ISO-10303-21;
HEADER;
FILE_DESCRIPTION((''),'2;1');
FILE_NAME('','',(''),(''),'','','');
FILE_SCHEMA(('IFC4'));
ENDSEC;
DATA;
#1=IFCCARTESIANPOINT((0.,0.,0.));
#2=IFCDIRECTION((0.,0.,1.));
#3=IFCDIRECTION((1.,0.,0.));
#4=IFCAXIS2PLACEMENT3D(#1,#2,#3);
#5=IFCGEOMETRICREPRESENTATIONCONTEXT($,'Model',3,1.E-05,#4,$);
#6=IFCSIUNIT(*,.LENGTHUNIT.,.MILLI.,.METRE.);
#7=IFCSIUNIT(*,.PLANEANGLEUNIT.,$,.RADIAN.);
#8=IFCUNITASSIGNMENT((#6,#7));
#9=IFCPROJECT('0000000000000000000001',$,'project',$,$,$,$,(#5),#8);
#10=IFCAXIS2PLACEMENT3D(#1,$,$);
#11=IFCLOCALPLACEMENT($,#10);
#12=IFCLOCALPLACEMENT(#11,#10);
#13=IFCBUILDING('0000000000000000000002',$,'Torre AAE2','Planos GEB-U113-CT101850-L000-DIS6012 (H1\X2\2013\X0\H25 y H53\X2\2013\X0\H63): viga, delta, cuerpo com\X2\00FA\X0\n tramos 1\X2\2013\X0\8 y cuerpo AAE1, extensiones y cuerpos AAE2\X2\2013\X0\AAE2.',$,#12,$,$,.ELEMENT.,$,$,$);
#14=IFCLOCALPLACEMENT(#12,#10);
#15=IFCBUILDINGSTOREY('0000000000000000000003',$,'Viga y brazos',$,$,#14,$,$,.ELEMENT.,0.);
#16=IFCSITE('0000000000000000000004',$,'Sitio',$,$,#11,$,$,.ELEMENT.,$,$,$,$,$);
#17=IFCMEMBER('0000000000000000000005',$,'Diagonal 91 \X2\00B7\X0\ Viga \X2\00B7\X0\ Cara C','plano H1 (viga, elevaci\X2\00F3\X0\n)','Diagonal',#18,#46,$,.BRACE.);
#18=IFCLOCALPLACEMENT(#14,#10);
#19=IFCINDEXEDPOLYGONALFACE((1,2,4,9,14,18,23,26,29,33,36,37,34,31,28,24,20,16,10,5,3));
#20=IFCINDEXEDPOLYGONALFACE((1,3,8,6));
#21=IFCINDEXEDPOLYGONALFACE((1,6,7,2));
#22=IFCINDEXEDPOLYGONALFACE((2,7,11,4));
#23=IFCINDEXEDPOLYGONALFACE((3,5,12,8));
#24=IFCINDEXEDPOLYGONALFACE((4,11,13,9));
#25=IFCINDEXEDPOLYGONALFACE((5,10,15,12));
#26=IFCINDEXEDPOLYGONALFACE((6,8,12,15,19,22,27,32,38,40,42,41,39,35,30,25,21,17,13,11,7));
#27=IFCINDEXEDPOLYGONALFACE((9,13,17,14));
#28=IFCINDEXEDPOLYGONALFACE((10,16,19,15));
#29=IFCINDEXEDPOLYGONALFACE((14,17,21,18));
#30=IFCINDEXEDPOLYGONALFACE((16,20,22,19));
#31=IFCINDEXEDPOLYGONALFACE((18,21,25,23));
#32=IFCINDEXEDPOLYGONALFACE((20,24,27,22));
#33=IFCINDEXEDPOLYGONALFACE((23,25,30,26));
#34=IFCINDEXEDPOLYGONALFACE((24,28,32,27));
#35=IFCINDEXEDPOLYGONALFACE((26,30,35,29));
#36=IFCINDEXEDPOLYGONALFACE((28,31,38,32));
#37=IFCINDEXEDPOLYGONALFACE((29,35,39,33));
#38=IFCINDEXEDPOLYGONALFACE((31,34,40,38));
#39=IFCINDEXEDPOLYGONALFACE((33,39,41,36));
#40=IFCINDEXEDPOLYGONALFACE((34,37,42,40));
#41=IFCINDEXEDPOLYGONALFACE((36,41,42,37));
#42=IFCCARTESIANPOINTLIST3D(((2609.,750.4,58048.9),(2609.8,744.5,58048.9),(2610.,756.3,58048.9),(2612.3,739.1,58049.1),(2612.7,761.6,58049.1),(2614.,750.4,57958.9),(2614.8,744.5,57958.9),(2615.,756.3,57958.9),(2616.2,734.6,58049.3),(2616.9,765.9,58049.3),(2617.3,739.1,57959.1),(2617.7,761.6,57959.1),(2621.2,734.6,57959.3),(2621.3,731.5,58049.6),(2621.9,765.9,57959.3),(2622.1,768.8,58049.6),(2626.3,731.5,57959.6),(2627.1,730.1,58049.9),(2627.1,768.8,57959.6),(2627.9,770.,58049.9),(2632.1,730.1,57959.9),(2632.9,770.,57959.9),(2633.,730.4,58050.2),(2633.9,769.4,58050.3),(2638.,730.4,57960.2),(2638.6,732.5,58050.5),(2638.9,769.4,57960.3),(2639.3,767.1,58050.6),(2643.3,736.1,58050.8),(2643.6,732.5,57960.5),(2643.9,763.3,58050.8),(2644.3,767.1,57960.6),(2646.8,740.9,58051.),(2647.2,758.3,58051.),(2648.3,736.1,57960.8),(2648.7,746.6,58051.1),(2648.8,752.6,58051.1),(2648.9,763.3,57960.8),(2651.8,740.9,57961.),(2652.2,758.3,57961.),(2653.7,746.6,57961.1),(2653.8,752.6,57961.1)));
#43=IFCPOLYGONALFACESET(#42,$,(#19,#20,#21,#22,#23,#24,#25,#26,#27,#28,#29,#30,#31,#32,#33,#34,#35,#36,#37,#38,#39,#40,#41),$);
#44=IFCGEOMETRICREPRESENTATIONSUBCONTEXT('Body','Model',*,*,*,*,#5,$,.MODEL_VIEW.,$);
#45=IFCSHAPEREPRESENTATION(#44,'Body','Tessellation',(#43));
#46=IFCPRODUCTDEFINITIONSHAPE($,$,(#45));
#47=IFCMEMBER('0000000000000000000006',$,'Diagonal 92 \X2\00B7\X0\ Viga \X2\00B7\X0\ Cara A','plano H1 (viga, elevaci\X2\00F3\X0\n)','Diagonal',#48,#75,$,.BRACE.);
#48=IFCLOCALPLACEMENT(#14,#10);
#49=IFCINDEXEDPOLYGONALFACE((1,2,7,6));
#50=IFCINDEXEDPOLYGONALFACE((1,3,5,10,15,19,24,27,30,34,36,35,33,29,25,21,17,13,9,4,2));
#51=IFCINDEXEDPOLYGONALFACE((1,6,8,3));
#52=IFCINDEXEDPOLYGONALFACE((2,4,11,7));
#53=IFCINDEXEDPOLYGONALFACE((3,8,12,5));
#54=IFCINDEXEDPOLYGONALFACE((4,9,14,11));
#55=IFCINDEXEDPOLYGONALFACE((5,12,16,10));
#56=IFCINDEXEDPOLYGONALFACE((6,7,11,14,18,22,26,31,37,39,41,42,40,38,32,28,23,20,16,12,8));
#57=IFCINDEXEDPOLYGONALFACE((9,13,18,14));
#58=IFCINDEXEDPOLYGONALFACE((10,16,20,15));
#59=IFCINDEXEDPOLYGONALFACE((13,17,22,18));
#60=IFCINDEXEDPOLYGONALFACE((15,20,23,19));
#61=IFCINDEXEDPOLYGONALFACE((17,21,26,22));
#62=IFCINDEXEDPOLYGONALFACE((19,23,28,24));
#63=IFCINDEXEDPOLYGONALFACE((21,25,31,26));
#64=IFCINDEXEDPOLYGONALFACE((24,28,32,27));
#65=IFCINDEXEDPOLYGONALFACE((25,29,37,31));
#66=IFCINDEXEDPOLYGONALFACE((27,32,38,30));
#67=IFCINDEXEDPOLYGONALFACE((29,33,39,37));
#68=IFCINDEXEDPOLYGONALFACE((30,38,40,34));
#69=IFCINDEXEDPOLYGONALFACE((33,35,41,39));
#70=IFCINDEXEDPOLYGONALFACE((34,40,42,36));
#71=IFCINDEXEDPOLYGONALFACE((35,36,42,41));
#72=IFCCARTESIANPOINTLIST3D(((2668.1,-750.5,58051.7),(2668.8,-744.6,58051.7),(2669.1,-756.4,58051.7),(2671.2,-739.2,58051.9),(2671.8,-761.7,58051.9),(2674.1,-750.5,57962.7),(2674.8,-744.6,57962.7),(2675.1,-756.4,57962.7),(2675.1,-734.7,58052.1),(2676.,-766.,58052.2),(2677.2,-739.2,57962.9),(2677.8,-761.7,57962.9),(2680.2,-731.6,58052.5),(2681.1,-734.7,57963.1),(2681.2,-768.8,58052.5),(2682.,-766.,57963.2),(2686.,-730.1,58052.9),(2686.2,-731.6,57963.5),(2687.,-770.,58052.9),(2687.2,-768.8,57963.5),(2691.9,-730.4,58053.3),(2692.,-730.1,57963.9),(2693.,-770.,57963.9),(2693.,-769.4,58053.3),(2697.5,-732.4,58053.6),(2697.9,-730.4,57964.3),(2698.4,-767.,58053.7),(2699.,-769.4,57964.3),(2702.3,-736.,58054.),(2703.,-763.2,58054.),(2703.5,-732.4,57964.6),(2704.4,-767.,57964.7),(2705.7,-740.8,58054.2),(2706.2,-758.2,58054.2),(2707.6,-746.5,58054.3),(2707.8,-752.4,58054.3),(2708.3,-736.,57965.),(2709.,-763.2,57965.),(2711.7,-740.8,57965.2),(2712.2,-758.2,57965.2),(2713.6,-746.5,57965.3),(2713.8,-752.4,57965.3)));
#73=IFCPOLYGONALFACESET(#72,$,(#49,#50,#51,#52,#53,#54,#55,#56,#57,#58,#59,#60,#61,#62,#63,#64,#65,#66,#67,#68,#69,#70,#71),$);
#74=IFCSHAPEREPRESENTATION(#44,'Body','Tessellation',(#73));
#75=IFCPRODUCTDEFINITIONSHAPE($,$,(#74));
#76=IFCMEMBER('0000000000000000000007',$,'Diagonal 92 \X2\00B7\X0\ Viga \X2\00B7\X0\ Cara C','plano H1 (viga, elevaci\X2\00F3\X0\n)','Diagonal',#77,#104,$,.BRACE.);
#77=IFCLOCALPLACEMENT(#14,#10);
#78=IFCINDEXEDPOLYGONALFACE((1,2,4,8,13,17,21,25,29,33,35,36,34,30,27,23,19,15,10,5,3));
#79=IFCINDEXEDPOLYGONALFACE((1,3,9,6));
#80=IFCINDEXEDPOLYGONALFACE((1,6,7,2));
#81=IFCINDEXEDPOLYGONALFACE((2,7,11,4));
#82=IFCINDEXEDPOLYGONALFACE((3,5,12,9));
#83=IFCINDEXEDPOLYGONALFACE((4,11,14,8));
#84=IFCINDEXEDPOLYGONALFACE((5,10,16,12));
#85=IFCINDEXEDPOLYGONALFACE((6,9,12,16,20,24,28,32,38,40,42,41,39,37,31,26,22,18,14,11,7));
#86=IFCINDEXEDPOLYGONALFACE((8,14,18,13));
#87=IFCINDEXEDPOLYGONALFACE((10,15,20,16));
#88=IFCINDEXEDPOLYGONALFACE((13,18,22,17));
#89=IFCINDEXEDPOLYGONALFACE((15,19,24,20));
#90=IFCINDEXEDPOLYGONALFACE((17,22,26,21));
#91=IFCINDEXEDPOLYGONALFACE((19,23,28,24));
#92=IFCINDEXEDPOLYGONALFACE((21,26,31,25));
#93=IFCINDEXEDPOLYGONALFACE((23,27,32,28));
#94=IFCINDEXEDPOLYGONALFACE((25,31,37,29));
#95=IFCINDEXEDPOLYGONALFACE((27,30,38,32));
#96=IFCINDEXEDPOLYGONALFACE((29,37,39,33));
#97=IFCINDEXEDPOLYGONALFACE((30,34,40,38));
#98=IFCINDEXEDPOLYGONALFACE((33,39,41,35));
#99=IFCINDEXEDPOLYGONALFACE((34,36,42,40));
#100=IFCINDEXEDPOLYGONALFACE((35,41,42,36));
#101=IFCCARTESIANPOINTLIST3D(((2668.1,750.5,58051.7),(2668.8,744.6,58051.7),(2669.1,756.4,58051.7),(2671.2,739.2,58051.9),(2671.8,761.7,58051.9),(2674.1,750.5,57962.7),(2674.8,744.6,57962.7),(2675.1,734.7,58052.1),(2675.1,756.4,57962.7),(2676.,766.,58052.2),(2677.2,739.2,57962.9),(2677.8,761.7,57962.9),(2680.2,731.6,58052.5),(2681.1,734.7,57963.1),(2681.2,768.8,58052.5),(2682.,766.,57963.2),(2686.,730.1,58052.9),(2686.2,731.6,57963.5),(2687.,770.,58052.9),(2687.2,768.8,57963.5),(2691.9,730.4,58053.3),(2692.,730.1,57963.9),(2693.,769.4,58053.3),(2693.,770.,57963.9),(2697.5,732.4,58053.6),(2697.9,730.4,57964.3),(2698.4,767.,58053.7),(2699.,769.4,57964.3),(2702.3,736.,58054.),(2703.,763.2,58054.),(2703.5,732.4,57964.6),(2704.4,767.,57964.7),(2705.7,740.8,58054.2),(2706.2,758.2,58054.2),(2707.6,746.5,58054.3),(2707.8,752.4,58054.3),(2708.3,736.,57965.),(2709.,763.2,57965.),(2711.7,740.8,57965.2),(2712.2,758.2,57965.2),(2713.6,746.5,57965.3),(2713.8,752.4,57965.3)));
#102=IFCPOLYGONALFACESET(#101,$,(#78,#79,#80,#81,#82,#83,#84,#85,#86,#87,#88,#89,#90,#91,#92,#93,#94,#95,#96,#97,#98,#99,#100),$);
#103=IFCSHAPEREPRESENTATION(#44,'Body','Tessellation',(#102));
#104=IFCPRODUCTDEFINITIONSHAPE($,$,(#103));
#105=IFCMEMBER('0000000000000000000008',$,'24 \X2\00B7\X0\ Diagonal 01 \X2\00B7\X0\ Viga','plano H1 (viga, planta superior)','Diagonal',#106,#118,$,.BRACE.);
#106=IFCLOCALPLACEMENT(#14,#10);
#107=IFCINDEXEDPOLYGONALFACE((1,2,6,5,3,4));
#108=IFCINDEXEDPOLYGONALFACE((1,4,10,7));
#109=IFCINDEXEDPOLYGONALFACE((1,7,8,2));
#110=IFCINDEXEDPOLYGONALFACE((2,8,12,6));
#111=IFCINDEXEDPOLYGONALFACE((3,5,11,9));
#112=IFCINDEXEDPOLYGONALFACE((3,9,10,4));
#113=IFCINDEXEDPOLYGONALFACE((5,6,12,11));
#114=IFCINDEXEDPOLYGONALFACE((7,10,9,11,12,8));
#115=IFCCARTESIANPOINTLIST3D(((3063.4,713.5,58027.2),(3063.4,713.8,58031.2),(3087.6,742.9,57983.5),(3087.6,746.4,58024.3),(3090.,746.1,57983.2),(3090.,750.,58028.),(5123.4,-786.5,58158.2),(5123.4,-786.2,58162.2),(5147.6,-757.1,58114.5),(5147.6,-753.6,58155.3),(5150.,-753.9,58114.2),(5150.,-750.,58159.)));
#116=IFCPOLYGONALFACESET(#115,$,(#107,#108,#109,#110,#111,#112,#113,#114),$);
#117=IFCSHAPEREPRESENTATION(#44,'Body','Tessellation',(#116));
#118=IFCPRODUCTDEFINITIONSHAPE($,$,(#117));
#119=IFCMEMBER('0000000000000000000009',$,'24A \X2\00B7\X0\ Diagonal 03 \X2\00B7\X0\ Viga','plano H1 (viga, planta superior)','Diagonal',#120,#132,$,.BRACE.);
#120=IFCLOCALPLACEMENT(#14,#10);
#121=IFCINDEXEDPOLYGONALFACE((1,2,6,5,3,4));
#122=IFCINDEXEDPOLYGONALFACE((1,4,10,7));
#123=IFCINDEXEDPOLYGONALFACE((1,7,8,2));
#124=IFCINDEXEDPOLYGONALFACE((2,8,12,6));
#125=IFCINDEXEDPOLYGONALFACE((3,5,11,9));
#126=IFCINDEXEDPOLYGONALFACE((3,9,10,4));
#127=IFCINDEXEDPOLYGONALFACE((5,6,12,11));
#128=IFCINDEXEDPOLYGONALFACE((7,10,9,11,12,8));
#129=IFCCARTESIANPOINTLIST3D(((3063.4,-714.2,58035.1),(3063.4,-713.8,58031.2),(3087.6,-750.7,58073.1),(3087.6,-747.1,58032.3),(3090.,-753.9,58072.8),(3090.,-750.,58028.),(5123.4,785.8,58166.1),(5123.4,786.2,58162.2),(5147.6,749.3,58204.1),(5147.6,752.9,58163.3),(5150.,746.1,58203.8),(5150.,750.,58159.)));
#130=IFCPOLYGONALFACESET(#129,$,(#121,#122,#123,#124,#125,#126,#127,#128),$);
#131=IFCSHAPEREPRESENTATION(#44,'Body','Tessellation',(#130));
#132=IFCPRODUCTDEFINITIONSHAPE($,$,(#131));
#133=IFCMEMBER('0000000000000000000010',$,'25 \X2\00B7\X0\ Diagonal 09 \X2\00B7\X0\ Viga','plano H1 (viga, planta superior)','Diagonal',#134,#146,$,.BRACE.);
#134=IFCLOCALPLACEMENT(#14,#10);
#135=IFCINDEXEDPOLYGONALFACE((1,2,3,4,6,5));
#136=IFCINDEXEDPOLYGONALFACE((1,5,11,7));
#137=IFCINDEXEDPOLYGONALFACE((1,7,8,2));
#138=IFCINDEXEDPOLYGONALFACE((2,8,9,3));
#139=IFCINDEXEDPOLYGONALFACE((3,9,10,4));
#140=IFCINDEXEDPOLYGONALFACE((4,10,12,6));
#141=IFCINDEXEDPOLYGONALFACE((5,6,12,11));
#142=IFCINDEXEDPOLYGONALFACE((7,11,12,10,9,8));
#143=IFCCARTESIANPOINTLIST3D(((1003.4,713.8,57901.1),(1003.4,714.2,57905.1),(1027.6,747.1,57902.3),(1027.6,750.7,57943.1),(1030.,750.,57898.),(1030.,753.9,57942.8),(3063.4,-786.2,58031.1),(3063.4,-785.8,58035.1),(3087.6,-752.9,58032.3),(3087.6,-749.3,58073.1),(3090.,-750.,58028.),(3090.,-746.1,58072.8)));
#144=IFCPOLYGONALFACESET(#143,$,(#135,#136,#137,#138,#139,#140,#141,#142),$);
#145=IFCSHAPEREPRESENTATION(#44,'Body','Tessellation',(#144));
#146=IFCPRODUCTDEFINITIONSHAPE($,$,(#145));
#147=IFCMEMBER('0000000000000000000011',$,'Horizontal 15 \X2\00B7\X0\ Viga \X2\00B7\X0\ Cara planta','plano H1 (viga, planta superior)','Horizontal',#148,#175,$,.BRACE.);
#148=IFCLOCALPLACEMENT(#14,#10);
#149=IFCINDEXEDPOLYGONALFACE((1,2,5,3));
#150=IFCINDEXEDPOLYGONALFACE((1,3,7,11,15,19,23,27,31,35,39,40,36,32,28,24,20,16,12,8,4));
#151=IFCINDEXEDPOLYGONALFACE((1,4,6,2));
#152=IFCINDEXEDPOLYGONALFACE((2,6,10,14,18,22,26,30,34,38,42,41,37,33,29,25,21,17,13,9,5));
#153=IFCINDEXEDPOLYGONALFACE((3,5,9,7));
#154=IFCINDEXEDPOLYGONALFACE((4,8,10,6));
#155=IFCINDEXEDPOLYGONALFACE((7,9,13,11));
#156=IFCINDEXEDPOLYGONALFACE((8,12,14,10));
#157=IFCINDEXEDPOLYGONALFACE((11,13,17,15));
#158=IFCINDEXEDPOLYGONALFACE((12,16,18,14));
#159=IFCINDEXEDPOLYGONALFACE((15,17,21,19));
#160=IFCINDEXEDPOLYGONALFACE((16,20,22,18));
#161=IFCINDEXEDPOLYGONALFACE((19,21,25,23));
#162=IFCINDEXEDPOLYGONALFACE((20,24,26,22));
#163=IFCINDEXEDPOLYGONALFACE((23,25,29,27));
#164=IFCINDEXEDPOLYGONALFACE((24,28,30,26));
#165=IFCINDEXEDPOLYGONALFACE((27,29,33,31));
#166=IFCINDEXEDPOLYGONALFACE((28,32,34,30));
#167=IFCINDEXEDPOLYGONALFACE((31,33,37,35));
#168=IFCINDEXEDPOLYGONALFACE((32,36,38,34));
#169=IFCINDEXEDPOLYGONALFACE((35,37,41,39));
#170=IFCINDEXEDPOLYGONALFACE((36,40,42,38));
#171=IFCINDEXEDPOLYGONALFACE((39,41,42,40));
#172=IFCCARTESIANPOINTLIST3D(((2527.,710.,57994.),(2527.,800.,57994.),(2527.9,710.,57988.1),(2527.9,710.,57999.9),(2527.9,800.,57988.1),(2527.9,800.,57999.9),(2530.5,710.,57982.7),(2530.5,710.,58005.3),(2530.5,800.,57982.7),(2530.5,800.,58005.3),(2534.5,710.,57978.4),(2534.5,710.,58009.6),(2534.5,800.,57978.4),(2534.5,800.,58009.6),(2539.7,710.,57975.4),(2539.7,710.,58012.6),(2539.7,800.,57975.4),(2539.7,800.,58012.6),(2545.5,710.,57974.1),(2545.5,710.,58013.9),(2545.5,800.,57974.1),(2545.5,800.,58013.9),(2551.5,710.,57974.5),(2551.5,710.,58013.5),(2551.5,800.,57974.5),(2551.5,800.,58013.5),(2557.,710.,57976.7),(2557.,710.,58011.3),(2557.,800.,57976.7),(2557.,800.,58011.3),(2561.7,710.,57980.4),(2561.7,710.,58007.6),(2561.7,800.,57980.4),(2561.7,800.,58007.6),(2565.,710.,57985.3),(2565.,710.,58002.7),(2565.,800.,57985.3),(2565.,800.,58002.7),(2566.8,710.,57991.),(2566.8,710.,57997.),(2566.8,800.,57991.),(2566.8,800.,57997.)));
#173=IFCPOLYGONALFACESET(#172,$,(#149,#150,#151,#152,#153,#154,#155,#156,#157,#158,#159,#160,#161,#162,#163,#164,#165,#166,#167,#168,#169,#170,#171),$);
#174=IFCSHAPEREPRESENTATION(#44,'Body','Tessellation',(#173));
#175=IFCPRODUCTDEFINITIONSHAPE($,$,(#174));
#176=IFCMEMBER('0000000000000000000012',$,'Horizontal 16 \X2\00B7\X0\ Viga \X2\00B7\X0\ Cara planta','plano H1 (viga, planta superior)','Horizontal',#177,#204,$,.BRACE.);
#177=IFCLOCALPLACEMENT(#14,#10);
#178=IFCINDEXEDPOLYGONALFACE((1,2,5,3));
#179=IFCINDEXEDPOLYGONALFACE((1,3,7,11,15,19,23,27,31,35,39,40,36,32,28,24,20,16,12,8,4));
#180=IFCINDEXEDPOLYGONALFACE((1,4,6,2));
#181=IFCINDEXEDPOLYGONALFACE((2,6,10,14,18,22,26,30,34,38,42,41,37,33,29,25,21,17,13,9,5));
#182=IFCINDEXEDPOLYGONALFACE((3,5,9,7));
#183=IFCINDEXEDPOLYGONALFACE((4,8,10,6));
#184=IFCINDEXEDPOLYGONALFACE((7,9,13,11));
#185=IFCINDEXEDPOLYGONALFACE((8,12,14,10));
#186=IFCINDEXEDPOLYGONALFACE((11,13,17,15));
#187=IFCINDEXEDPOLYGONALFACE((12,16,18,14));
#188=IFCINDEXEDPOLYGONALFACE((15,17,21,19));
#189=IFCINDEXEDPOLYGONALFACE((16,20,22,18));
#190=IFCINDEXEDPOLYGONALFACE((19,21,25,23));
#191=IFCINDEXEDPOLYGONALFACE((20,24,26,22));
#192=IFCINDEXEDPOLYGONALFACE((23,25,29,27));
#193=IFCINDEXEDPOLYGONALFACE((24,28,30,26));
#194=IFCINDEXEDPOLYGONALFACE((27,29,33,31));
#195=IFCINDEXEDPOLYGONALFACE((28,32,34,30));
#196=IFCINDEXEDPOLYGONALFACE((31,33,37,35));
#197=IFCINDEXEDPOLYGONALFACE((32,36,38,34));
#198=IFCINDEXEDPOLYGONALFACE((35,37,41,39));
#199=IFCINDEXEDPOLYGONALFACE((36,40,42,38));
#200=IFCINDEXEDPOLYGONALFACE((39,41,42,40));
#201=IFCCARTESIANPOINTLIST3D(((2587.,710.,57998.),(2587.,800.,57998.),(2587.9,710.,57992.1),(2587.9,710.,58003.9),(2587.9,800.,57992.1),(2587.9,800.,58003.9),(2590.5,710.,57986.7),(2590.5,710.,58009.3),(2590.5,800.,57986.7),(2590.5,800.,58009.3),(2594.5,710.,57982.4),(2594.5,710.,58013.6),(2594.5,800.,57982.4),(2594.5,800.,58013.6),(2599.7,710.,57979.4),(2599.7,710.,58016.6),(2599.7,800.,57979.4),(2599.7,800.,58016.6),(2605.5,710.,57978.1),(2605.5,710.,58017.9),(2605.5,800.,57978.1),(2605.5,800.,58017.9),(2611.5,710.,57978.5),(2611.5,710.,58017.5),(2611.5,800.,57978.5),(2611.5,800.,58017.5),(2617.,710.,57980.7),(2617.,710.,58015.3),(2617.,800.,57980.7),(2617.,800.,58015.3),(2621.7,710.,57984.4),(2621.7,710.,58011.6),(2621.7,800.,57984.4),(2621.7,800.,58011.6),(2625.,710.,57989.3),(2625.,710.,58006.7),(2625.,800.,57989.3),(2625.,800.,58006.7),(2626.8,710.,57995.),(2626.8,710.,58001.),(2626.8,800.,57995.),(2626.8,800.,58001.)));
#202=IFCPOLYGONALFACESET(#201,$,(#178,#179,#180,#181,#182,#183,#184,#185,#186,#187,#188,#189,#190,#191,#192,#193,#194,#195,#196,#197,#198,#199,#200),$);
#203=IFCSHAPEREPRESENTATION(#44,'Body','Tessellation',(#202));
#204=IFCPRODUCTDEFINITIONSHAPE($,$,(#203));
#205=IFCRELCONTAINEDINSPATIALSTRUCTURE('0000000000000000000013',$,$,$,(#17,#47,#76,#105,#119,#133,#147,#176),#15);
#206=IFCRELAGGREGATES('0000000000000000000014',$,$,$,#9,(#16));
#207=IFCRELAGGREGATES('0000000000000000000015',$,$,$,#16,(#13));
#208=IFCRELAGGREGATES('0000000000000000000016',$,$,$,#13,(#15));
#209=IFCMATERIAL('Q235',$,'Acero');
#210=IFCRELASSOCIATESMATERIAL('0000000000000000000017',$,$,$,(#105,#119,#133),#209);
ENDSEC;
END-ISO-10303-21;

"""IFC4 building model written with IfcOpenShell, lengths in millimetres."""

from ifc_helpers import new_model, si_unit, frame, frame_2d, origin, origin_with_axes, place, context, subcontext, project, spatial, circle, l_section, extrude, material, element, save


model = new_model("IFC4")

# Units and contexts
model_context = context("Model", 3, precision=1e-05, world=origin_with_axes())
body_context = subcontext(model_context, "Body", "Model", "MODEL_VIEW")
ifc_project = project(units=[si_unit("LENGTHUNIT", "METRE", prefix="MILLI"), si_unit("PLANEANGLEUNIT", "RADIAN")], contexts=[model_context])

# Site, building, storey
site_placement = place(None, origin())
site = spatial("IfcSite", under=ifc_project, at=site_placement, Name="Sitio", CompositionType="ELEMENT")
building_placement = place(site_placement, origin())
building = spatial("IfcBuilding", under=site, at=building_placement, Name="Torre AAE2", Description="Planos GEB-U113-CT101850-L000-DIS6012 (H1–H25 y H53–H63): viga, delta, cuerpo común tramos 1–8 y cuerpo AAE1, extensiones y cuerpos AAE2–AAE2.", CompositionType="ELEMENT")
storey_placement = place(building_placement, origin())
storey = spatial("IfcBuildingStorey", under=building, at=storey_placement, Name="Viga y brazos", CompositionType="ELEMENT", Elevation=0.0)

# Members
ifc_material = material(Name="Q235", Category="Acero")
for number, where, z_axis, x_axis, name in (
    (1, (2634.0, 750.0, 57960.0), (-0.05547, 0.0, 0.99846), (-0.960111, -0.274484, -0.05334), "Diagonal 91 · Viga · Cara C"),
):
    element("IfcMember", number, at=place(storey_placement, frame(where, z_axis=z_axis, x_axis=x_axis)), inside=storey, Name=name, Description="plano H1 (viga, elevación)", ObjectType="Diagonal", PredefinedType="BRACE", context=body_context, shape_type="SweptSolid", body=[
        extrude(circle(Radius=20.0), None, (0.0, 0.0, 1.0), 90.1),
    ])
for number, where, z_axis, x_axis, name in (
    (2, (2694.0, -750.0, 57964.0), (-0.067263, 0.0, 0.997735), (-0.960948, 0.26904, -0.064783), "Diagonal 92 · Viga · Cara A"),
    (3, (2694.0, 750.0, 57964.0), (-0.067263, 0.0, 0.997735), (-0.960948, -0.26904, -0.064783), "Diagonal 92 · Viga · Cara C"),
):
    element("IfcMember", number, at=place(storey_placement, frame(where, z_axis=z_axis, x_axis=x_axis)), inside=storey, Name=name, Description="plano H1 (viga, elevación)", ObjectType="Diagonal", PredefinedType="BRACE", context=body_context, shape_type="SweptSolid", body=[
        extrude(circle(Radius=20.0), None, (0.0, 0.0, 1.0), 89.2),
    ])
for number, where, z_axis, x_axis, name in (
    (4, (3090.0, 750.0, 58028.0), (0.80733, -0.587862, 0.05134), (-0.5901, -0.804269, 0.07024), "24 · Diagonal 01 · Viga"),
    (5, (3090.0, -750.0, 58028.0), (0.80733, 0.587862, 0.05134), (-0.5901, 0.804269, 0.07024), "24A · Diagonal 03 · Viga"),
):
    element("IfcMember", number, at=place(storey_placement, frame(where, z_axis=z_axis, x_axis=x_axis)), inside=storey, material=ifc_material, Name=name, Description="plano H1 (viga, planta superior)", ObjectType="Diagonal", PredefinedType="BRACE", context=body_context, shape_type="SweptSolid", body=[
        extrude(l_section(Depth=45.0, Width=45.0, Thickness=4.0, at=frame_2d((22.5, 22.5))), None, (0.0, 0.0, 1.0), 2551.6),
    ])
member_1_placement = place(storey_placement, frame((3090.0, -750.0, 58028.0), z_axis=(-0.807347, 0.587874, -0.050949), x_axis=(-0.590077, -0.804332, 0.069709)))
element("IfcMember", 6, at=member_1_placement, inside=storey, material=ifc_material, Name="25 · Diagonal 09 · Viga", Description="plano H1 (viga, planta superior)", ObjectType="Diagonal", PredefinedType="BRACE", context=body_context, shape_type="SweptSolid", body=[
    extrude(l_section(Depth=45.0, Width=45.0, Thickness=4.0, at=frame_2d((22.5, 22.5))), None, (0.0, 0.0, 1.0), 2551.6),
])
for number, where, z_axis, x_axis, name in (
    (7, (2547.0, 710.0, 57994.0), (0.0, 1.0, 0.0), (-1.0, 0.0, 0.0), "Horizontal 15 · Viga · Cara planta"),
    (8, (2607.0, 710.0, 57998.0), (0.0, 1.0, 0.0), (-1.0, 0.0, 0.0), "Horizontal 16 · Viga · Cara planta"),
):
    element("IfcMember", number, at=place(storey_placement, frame(where, z_axis=z_axis, x_axis=x_axis)), inside=storey, Name=name, Description="plano H1 (viga, planta superior)", ObjectType="Horizontal", PredefinedType="BRACE", context=body_context, shape_type="SweptSolid", body=[
        extrude(circle(Radius=20.0), None, (0.0, 0.0, 1.0), 90.0),
    ])

save(model, "model.ifc")
